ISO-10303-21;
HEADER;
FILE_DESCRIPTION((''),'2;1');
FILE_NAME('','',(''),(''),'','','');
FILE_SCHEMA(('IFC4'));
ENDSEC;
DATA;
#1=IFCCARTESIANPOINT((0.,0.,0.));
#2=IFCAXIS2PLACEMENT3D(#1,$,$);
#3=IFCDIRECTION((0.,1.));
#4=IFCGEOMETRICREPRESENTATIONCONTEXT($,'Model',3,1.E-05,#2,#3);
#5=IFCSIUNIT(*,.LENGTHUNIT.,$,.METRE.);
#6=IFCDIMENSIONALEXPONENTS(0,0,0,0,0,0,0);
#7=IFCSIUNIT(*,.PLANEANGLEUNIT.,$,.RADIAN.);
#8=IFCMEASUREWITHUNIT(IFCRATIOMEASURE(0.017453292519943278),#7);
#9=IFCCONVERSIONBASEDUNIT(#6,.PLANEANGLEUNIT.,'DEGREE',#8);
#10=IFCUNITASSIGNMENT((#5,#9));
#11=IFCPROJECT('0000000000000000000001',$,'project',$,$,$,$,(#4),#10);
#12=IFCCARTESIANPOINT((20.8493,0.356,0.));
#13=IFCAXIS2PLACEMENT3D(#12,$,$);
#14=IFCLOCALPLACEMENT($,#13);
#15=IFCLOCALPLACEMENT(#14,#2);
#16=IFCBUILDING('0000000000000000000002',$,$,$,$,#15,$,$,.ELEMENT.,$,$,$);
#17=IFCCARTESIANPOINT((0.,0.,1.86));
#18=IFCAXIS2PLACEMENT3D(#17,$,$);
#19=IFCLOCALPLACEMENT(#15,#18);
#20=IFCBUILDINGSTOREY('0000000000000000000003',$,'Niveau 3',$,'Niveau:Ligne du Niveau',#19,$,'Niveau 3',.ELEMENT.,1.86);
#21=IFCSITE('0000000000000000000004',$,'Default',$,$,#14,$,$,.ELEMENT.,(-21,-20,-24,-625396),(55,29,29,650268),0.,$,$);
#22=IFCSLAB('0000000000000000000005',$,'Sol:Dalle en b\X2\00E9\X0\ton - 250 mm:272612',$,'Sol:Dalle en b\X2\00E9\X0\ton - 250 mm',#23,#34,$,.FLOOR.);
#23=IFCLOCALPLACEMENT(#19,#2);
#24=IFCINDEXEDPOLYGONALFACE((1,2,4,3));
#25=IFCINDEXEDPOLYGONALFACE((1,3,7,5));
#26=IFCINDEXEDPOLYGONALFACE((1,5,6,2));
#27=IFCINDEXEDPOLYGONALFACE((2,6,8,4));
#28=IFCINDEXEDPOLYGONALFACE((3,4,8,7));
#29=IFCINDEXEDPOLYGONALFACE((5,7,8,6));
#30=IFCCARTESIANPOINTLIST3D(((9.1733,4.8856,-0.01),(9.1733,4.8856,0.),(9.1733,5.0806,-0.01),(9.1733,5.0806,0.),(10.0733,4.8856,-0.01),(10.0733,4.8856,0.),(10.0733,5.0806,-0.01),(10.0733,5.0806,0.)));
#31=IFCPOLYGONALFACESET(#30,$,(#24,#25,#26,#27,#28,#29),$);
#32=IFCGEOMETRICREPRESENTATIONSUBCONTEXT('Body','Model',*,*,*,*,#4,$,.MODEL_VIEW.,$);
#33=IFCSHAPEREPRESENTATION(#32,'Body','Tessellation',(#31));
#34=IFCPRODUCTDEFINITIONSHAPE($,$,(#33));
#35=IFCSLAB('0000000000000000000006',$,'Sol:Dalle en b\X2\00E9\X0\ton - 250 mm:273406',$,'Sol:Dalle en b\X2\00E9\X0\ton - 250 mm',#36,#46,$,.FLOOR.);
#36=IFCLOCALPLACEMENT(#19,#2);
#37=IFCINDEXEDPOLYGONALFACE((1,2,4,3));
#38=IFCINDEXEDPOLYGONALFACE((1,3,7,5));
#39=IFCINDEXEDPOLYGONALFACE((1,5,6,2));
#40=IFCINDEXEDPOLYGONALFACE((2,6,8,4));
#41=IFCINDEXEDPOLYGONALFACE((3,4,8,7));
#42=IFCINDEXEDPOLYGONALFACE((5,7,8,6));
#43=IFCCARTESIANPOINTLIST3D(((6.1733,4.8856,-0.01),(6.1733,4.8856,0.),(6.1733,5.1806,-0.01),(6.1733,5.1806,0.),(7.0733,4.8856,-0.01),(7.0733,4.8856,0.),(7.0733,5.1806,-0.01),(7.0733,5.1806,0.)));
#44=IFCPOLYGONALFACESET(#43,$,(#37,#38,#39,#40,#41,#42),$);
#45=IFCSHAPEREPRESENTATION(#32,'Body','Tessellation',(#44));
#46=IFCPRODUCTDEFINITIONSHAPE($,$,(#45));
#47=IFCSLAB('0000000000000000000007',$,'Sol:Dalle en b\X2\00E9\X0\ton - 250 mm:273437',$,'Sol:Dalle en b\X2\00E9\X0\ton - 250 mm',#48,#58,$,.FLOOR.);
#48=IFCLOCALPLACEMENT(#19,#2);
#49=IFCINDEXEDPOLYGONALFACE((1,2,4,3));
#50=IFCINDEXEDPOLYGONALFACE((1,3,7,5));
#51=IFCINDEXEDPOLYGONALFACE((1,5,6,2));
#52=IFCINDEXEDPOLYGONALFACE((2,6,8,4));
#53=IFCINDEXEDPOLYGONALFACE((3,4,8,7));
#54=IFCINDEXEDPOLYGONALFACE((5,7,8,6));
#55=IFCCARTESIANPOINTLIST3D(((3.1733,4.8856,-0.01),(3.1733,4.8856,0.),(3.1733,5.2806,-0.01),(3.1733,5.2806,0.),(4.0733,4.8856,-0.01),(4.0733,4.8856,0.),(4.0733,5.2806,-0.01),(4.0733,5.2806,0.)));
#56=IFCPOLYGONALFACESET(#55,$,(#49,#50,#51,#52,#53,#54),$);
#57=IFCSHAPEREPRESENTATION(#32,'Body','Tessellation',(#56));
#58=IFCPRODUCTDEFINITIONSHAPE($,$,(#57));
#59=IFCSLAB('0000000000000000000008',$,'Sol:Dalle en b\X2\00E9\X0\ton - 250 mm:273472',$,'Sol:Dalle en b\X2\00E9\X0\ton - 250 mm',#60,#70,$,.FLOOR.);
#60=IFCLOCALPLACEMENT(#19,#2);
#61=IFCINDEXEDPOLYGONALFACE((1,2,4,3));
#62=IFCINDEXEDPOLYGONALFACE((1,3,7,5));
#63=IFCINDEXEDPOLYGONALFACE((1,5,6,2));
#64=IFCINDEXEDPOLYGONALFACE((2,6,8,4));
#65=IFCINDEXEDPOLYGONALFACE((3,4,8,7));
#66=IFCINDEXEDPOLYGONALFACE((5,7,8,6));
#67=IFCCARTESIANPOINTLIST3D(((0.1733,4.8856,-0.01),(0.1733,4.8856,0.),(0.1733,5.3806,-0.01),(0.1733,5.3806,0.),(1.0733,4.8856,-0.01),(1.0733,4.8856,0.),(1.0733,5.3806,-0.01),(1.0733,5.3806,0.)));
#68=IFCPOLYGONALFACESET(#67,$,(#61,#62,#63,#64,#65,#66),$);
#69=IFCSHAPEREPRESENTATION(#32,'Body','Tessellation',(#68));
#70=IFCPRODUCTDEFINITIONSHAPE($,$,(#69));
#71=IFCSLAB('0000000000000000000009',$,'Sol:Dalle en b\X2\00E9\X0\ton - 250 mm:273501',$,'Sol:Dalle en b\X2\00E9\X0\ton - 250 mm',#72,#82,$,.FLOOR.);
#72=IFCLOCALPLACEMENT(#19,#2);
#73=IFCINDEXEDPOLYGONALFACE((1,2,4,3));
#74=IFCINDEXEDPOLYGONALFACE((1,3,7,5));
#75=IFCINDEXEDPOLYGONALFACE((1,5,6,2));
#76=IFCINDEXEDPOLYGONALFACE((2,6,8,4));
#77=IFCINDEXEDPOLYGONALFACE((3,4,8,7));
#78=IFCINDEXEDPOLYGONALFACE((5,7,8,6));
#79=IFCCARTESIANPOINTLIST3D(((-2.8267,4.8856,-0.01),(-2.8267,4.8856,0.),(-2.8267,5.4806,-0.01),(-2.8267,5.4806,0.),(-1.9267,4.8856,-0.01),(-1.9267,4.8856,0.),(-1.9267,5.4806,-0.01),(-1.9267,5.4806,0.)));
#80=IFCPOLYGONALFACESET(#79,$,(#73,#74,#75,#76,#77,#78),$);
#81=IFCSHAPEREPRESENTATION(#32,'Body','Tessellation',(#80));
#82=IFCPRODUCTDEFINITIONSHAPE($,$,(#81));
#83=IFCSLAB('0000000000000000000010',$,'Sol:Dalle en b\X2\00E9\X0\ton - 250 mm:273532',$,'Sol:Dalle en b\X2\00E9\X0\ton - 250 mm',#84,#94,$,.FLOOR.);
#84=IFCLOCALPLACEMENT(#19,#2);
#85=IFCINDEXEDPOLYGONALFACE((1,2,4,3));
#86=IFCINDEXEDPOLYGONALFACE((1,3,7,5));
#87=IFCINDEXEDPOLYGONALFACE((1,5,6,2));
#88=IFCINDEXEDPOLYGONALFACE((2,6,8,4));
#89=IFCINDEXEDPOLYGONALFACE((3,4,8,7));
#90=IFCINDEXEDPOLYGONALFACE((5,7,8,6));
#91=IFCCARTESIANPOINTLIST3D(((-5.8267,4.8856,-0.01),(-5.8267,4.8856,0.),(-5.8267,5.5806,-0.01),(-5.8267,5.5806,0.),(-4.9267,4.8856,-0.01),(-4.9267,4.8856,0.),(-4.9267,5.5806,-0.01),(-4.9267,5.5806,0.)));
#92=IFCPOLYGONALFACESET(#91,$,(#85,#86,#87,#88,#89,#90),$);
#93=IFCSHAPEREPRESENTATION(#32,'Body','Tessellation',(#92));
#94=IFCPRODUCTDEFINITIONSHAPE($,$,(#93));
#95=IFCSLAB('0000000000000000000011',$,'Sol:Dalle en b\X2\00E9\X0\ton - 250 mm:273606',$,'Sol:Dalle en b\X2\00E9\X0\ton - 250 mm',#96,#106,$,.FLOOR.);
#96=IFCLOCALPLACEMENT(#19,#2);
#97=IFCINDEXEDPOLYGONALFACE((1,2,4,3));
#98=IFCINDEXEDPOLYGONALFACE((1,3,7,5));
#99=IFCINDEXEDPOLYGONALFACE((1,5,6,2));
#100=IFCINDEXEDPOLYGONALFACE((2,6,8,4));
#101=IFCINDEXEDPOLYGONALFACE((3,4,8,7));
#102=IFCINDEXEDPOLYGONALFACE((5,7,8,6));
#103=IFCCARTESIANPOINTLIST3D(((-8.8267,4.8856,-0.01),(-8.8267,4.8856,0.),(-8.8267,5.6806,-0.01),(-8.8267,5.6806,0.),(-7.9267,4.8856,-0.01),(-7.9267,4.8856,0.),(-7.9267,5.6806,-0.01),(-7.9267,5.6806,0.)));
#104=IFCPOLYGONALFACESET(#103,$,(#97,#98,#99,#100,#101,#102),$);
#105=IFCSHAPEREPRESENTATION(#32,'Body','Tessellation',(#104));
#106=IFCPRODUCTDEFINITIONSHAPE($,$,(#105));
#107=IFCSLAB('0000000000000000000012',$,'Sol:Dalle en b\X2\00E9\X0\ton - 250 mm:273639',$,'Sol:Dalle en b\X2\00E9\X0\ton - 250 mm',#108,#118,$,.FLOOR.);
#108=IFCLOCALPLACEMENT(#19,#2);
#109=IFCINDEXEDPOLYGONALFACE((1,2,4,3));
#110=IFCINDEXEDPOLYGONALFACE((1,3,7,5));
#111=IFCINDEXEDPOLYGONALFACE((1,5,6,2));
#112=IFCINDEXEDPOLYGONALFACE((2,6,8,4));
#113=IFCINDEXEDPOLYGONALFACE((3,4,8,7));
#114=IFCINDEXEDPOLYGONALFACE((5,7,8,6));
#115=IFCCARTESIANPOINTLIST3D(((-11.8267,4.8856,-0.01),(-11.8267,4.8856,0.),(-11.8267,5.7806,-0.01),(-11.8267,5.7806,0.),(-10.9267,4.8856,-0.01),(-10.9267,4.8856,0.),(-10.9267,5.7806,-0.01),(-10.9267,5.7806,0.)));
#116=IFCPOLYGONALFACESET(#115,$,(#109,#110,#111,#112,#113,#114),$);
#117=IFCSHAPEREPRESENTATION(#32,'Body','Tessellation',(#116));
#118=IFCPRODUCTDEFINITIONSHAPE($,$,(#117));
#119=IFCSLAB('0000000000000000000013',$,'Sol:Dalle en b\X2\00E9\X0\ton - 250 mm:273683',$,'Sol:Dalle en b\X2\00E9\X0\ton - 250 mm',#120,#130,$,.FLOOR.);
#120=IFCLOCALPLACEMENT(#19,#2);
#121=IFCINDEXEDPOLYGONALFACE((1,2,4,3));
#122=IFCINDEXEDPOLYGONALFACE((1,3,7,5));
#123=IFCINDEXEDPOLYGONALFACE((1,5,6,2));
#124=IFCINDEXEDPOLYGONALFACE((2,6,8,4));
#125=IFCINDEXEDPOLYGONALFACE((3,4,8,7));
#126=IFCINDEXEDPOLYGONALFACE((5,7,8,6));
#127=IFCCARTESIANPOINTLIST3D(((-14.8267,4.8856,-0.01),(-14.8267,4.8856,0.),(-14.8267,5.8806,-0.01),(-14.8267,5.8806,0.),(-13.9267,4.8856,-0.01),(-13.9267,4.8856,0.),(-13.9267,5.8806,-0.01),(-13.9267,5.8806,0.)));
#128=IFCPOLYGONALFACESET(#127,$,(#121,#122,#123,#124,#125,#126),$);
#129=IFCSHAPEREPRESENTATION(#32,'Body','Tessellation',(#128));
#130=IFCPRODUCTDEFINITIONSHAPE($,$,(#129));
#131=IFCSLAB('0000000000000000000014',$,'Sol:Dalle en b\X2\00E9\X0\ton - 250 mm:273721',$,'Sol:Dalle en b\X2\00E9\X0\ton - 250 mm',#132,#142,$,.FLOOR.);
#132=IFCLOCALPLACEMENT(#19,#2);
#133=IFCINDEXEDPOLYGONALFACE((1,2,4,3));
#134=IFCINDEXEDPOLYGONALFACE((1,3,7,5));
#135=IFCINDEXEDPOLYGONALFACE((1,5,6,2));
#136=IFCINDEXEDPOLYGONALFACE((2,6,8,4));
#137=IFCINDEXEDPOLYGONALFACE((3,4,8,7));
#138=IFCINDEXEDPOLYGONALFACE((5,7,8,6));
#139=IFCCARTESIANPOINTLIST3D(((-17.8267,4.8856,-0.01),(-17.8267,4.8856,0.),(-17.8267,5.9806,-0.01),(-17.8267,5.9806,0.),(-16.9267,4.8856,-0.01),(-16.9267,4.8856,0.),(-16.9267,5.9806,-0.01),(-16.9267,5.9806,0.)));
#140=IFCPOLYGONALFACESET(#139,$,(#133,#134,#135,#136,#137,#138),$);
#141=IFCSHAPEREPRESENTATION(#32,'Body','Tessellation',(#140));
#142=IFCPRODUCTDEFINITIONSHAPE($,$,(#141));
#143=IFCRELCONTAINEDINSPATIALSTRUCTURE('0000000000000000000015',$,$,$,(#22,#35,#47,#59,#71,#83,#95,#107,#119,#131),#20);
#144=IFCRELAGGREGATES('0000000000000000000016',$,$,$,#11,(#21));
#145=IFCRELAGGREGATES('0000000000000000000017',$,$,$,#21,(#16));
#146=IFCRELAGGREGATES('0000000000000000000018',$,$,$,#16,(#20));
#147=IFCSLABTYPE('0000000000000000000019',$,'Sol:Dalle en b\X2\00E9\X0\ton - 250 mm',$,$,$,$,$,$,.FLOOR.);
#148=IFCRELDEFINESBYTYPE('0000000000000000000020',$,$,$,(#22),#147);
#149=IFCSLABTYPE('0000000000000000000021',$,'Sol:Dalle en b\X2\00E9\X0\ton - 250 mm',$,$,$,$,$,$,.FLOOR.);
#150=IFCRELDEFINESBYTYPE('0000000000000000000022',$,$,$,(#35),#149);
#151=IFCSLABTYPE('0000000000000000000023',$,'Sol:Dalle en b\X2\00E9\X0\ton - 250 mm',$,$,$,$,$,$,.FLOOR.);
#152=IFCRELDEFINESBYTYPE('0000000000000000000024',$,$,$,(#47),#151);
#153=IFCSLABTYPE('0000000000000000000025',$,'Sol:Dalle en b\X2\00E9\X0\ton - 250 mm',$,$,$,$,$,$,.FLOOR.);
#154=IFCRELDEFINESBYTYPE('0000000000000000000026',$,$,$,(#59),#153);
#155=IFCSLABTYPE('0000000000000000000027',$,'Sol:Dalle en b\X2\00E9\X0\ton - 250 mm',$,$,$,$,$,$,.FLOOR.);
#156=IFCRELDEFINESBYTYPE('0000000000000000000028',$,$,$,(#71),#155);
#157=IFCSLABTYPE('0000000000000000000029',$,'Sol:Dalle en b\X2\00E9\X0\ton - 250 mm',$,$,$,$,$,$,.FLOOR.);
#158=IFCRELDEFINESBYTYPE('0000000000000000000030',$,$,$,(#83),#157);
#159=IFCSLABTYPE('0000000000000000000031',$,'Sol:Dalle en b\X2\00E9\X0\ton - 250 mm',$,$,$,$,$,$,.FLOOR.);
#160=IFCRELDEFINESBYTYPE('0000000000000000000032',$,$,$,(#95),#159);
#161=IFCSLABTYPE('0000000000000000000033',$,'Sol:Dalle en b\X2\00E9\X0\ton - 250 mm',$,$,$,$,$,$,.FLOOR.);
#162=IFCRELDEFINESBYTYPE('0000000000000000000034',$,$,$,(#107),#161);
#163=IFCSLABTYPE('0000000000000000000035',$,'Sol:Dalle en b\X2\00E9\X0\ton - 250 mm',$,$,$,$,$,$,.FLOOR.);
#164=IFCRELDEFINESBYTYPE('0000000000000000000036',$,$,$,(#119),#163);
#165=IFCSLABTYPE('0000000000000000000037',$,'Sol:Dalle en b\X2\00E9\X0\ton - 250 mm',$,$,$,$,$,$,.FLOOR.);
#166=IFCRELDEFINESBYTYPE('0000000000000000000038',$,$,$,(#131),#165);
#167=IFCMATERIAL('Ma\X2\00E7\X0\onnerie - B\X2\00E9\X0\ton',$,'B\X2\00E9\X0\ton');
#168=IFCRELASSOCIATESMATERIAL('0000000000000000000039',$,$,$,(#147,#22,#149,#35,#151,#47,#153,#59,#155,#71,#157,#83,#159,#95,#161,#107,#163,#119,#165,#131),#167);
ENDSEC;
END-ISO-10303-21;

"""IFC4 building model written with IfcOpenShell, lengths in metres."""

from ifc_helpers import new_model, entity, si_unit, converted_unit, direction, frame, origin, place, context, subcontext, project, spatial, indexed_curve, outline, extrude, material, type_object, element, save


model = new_model("IFC4")

# Units and contexts
model_context = context("Model", 3, precision=1e-05, world=origin(), true_north=direction((0.0, 1.0)))
body_context = subcontext(model_context, "Body", "Model", "MODEL_VIEW")
ifc_project = project(units=[si_unit("LENGTHUNIT", "METRE"), converted_unit("PLANEANGLEUNIT", "DEGREE", entity("IfcRatioMeasure", 0.017453292519943278), si_unit("PLANEANGLEUNIT", "RADIAN"), dimensions=[0, 0, 0, 0, 0, 0, 0])], contexts=[model_context])

# Site, building, storey
site_placement = place(None, frame((20.8493, 0.356, 0.0)))
site = spatial("IfcSite", under=ifc_project, at=site_placement, Name="Default", CompositionType="ELEMENT", RefLatitude=(-21, -20, -24, -625396), RefLongitude=(55, 29, 29, 650268), RefElevation=0.0)
building_placement = place(site_placement, origin())
building = spatial("IfcBuilding", under=site, at=building_placement, CompositionType="ELEMENT")
storey_placement = place(building_placement, frame((0.0, 0.0, 1.86)))
storey = spatial("IfcBuildingStorey", under=building, at=storey_placement, Name="Niveau 3", ObjectType="Niveau:Ligne du Niveau", LongName="Niveau 3", CompositionType="ELEMENT", Elevation=1.86)

# Slabs
ifc_material = material(Name="Maçonnerie - Béton", Category="Béton")
slab_type_1 = type_object("IfcSlabType", Name="Sol:Dalle en béton - 250 mm", PredefinedType="FLOOR", material=ifc_material)
slab_1_placement = place(storey_placement, origin())
element("IfcSlab", 1, at=slab_1_placement, inside=storey, type_object=slab_type_1, material=ifc_material, Name="Sol:Dalle en béton - 250 mm:272612", ObjectType="Sol:Dalle en béton - 250 mm", PredefinedType="FLOOR", context=body_context, shape_type="SweptSolid", body=[
    extrude(outline(indexed_curve([(-0.0975, -0.45), (0.0975, -0.45), (0.0975, 0.45), (-0.0975, 0.45), (-0.0975, -0.45)], self_intersect=False)), frame((9.6233, 4.9831, 0.0), z_axis=(0.0, 0.0, -1.0), x_axis=(0.0, 1.0, 0.0)), (0.0, 0.0, 1.0), 0.01),
])
slab_type_2 = type_object("IfcSlabType", Name="Sol:Dalle en béton - 250 mm", PredefinedType="FLOOR", material=ifc_material)
slab_2_placement = place(storey_placement, origin())
element("IfcSlab", 2, at=slab_2_placement, inside=storey, type_object=slab_type_2, material=ifc_material, Name="Sol:Dalle en béton - 250 mm:273406", ObjectType="Sol:Dalle en béton - 250 mm", PredefinedType="FLOOR", context=body_context, shape_type="SweptSolid", body=[
    extrude(outline(indexed_curve([(-0.1475, -0.45), (0.1475, -0.45), (0.1475, 0.45), (-0.1475, 0.45), (-0.1475, -0.45)], self_intersect=False)), frame((6.6233, 5.0331, 0.0), z_axis=(0.0, 0.0, -1.0), x_axis=(0.0, 1.0, 0.0)), (0.0, 0.0, 1.0), 0.01),
])
slab_type_3 = type_object("IfcSlabType", Name="Sol:Dalle en béton - 250 mm", PredefinedType="FLOOR", material=ifc_material)
slab_3_placement = place(storey_placement, origin())
element("IfcSlab", 3, at=slab_3_placement, inside=storey, type_object=slab_type_3, material=ifc_material, Name="Sol:Dalle en béton - 250 mm:273437", ObjectType="Sol:Dalle en béton - 250 mm", PredefinedType="FLOOR", context=body_context, shape_type="SweptSolid", body=[
    extrude(outline(indexed_curve([(-0.1975, -0.45), (0.1975, -0.45), (0.1975, 0.45), (-0.1975, 0.45), (-0.1975, -0.45)], self_intersect=False)), frame((3.6233, 5.0831, 0.0), z_axis=(0.0, 0.0, -1.0), x_axis=(0.0, 1.0, 0.0)), (0.0, 0.0, 1.0), 0.01),
])
slab_type_4 = type_object("IfcSlabType", Name="Sol:Dalle en béton - 250 mm", PredefinedType="FLOOR", material=ifc_material)
slab_4_placement = place(storey_placement, origin())
element("IfcSlab", 4, at=slab_4_placement, inside=storey, type_object=slab_type_4, material=ifc_material, Name="Sol:Dalle en béton - 250 mm:273472", ObjectType="Sol:Dalle en béton - 250 mm", PredefinedType="FLOOR", context=body_context, shape_type="SweptSolid", body=[
    extrude(outline(indexed_curve([(-0.2475, -0.45), (0.2475, -0.45), (0.2475, 0.45), (-0.2475, 0.45), (-0.2475, -0.45)], self_intersect=False)), frame((0.6233, 5.1331, 0.0), z_axis=(0.0, 0.0, -1.0), x_axis=(0.0, 1.0, 0.0)), (0.0, 0.0, 1.0), 0.01),
])
slab_type_5 = type_object("IfcSlabType", Name="Sol:Dalle en béton - 250 mm", PredefinedType="FLOOR", material=ifc_material)
slab_5_placement = place(storey_placement, origin())
element("IfcSlab", 5, at=slab_5_placement, inside=storey, type_object=slab_type_5, material=ifc_material, Name="Sol:Dalle en béton - 250 mm:273501", ObjectType="Sol:Dalle en béton - 250 mm", PredefinedType="FLOOR", context=body_context, shape_type="SweptSolid", body=[
    extrude(outline(indexed_curve([(-0.2975, -0.45), (0.2975, -0.45), (0.2975, 0.45), (-0.2975, 0.45), (-0.2975, -0.45)], self_intersect=False)), frame((-2.3767, 5.1831, 0.0), z_axis=(0.0, 0.0, -1.0), x_axis=(0.0, 1.0, 0.0)), (0.0, 0.0, 1.0), 0.01),
])
slab_type_6 = type_object("IfcSlabType", Name="Sol:Dalle en béton - 250 mm", PredefinedType="FLOOR", material=ifc_material)
slab_6_placement = place(storey_placement, origin())
element("IfcSlab", 6, at=slab_6_placement, inside=storey, type_object=slab_type_6, material=ifc_material, Name="Sol:Dalle en béton - 250 mm:273532", ObjectType="Sol:Dalle en béton - 250 mm", PredefinedType="FLOOR", context=body_context, shape_type="SweptSolid", body=[
    extrude(outline(indexed_curve([(-0.3475, -0.45), (0.3475, -0.45), (0.3475, 0.45), (-0.3475, 0.45), (-0.3475, -0.45)], self_intersect=False)), frame((-5.3767, 5.2331, 0.0), z_axis=(0.0, 0.0, -1.0), x_axis=(0.0, 1.0, 0.0)), (0.0, 0.0, 1.0), 0.01),
])
slab_type_7 = type_object("IfcSlabType", Name="Sol:Dalle en béton - 250 mm", PredefinedType="FLOOR", material=ifc_material)
slab_7_placement = place(storey_placement, origin())
element("IfcSlab", 7, at=slab_7_placement, inside=storey, type_object=slab_type_7, material=ifc_material, Name="Sol:Dalle en béton - 250 mm:273606", ObjectType="Sol:Dalle en béton - 250 mm", PredefinedType="FLOOR", context=body_context, shape_type="SweptSolid", body=[
    extrude(outline(indexed_curve([(-0.3975, -0.45), (0.3975, -0.45), (0.3975, 0.45), (-0.3975, 0.45), (-0.3975, -0.45)], self_intersect=False)), frame((-8.3767, 5.2831, 0.0), z_axis=(0.0, 0.0, -1.0), x_axis=(0.0, 1.0, 0.0)), (0.0, 0.0, 1.0), 0.01),
])
slab_type_8 = type_object("IfcSlabType", Name="Sol:Dalle en béton - 250 mm", PredefinedType="FLOOR", material=ifc_material)
slab_8_placement = place(storey_placement, origin())
element("IfcSlab", 8, at=slab_8_placement, inside=storey, type_object=slab_type_8, material=ifc_material, Name="Sol:Dalle en béton - 250 mm:273639", ObjectType="Sol:Dalle en béton - 250 mm", PredefinedType="FLOOR", context=body_context, shape_type="SweptSolid", body=[
    extrude(outline(indexed_curve([(-0.4475, -0.45), (0.4475, -0.45), (0.4475, 0.45), (-0.4475, 0.45), (-0.4475, -0.45)], self_intersect=False)), frame((-11.3767, 5.3331, 0.0), z_axis=(0.0, 0.0, -1.0), x_axis=(0.0, 1.0, 0.0)), (0.0, 0.0, 1.0), 0.01),
])
slab_type_9 = type_object("IfcSlabType", Name="Sol:Dalle en béton - 250 mm", PredefinedType="FLOOR", material=ifc_material)
slab_9_placement = place(storey_placement, origin())
element("IfcSlab", 9, at=slab_9_placement, inside=storey, type_object=slab_type_9, material=ifc_material, Name="Sol:Dalle en béton - 250 mm:273683", ObjectType="Sol:Dalle en béton - 250 mm", PredefinedType="FLOOR", context=body_context, shape_type="SweptSolid", body=[
    extrude(outline(indexed_curve([(-0.4975, -0.45), (0.4975, -0.45), (0.4975, 0.45), (-0.4975, 0.45), (-0.4975, -0.45)], self_intersect=False)), frame((-14.3767, 5.3831, 0.0), z_axis=(0.0, 0.0, -1.0), x_axis=(0.0, 1.0, 0.0)), (0.0, 0.0, 1.0), 0.01),
])
slab_type_10 = type_object("IfcSlabType", Name="Sol:Dalle en béton - 250 mm", PredefinedType="FLOOR", material=ifc_material)
slab_10_placement = place(storey_placement, origin())
element("IfcSlab", 10, at=slab_10_placement, inside=storey, type_object=slab_type_10, material=ifc_material, Name="Sol:Dalle en béton - 250 mm:273721", ObjectType="Sol:Dalle en béton - 250 mm", PredefinedType="FLOOR", context=body_context, shape_type="SweptSolid", body=[
    extrude(outline(indexed_curve([(-0.5475, -0.45), (0.5475, -0.45), (0.5475, 0.45), (-0.5475, 0.45), (-0.5475, -0.45)], self_intersect=False)), frame((-17.3767, 5.4331, 0.0), z_axis=(0.0, 0.0, -1.0), x_axis=(0.0, 1.0, 0.0)), (0.0, 0.0, 1.0), 0.01),
])

save(model, "model.ifc")
